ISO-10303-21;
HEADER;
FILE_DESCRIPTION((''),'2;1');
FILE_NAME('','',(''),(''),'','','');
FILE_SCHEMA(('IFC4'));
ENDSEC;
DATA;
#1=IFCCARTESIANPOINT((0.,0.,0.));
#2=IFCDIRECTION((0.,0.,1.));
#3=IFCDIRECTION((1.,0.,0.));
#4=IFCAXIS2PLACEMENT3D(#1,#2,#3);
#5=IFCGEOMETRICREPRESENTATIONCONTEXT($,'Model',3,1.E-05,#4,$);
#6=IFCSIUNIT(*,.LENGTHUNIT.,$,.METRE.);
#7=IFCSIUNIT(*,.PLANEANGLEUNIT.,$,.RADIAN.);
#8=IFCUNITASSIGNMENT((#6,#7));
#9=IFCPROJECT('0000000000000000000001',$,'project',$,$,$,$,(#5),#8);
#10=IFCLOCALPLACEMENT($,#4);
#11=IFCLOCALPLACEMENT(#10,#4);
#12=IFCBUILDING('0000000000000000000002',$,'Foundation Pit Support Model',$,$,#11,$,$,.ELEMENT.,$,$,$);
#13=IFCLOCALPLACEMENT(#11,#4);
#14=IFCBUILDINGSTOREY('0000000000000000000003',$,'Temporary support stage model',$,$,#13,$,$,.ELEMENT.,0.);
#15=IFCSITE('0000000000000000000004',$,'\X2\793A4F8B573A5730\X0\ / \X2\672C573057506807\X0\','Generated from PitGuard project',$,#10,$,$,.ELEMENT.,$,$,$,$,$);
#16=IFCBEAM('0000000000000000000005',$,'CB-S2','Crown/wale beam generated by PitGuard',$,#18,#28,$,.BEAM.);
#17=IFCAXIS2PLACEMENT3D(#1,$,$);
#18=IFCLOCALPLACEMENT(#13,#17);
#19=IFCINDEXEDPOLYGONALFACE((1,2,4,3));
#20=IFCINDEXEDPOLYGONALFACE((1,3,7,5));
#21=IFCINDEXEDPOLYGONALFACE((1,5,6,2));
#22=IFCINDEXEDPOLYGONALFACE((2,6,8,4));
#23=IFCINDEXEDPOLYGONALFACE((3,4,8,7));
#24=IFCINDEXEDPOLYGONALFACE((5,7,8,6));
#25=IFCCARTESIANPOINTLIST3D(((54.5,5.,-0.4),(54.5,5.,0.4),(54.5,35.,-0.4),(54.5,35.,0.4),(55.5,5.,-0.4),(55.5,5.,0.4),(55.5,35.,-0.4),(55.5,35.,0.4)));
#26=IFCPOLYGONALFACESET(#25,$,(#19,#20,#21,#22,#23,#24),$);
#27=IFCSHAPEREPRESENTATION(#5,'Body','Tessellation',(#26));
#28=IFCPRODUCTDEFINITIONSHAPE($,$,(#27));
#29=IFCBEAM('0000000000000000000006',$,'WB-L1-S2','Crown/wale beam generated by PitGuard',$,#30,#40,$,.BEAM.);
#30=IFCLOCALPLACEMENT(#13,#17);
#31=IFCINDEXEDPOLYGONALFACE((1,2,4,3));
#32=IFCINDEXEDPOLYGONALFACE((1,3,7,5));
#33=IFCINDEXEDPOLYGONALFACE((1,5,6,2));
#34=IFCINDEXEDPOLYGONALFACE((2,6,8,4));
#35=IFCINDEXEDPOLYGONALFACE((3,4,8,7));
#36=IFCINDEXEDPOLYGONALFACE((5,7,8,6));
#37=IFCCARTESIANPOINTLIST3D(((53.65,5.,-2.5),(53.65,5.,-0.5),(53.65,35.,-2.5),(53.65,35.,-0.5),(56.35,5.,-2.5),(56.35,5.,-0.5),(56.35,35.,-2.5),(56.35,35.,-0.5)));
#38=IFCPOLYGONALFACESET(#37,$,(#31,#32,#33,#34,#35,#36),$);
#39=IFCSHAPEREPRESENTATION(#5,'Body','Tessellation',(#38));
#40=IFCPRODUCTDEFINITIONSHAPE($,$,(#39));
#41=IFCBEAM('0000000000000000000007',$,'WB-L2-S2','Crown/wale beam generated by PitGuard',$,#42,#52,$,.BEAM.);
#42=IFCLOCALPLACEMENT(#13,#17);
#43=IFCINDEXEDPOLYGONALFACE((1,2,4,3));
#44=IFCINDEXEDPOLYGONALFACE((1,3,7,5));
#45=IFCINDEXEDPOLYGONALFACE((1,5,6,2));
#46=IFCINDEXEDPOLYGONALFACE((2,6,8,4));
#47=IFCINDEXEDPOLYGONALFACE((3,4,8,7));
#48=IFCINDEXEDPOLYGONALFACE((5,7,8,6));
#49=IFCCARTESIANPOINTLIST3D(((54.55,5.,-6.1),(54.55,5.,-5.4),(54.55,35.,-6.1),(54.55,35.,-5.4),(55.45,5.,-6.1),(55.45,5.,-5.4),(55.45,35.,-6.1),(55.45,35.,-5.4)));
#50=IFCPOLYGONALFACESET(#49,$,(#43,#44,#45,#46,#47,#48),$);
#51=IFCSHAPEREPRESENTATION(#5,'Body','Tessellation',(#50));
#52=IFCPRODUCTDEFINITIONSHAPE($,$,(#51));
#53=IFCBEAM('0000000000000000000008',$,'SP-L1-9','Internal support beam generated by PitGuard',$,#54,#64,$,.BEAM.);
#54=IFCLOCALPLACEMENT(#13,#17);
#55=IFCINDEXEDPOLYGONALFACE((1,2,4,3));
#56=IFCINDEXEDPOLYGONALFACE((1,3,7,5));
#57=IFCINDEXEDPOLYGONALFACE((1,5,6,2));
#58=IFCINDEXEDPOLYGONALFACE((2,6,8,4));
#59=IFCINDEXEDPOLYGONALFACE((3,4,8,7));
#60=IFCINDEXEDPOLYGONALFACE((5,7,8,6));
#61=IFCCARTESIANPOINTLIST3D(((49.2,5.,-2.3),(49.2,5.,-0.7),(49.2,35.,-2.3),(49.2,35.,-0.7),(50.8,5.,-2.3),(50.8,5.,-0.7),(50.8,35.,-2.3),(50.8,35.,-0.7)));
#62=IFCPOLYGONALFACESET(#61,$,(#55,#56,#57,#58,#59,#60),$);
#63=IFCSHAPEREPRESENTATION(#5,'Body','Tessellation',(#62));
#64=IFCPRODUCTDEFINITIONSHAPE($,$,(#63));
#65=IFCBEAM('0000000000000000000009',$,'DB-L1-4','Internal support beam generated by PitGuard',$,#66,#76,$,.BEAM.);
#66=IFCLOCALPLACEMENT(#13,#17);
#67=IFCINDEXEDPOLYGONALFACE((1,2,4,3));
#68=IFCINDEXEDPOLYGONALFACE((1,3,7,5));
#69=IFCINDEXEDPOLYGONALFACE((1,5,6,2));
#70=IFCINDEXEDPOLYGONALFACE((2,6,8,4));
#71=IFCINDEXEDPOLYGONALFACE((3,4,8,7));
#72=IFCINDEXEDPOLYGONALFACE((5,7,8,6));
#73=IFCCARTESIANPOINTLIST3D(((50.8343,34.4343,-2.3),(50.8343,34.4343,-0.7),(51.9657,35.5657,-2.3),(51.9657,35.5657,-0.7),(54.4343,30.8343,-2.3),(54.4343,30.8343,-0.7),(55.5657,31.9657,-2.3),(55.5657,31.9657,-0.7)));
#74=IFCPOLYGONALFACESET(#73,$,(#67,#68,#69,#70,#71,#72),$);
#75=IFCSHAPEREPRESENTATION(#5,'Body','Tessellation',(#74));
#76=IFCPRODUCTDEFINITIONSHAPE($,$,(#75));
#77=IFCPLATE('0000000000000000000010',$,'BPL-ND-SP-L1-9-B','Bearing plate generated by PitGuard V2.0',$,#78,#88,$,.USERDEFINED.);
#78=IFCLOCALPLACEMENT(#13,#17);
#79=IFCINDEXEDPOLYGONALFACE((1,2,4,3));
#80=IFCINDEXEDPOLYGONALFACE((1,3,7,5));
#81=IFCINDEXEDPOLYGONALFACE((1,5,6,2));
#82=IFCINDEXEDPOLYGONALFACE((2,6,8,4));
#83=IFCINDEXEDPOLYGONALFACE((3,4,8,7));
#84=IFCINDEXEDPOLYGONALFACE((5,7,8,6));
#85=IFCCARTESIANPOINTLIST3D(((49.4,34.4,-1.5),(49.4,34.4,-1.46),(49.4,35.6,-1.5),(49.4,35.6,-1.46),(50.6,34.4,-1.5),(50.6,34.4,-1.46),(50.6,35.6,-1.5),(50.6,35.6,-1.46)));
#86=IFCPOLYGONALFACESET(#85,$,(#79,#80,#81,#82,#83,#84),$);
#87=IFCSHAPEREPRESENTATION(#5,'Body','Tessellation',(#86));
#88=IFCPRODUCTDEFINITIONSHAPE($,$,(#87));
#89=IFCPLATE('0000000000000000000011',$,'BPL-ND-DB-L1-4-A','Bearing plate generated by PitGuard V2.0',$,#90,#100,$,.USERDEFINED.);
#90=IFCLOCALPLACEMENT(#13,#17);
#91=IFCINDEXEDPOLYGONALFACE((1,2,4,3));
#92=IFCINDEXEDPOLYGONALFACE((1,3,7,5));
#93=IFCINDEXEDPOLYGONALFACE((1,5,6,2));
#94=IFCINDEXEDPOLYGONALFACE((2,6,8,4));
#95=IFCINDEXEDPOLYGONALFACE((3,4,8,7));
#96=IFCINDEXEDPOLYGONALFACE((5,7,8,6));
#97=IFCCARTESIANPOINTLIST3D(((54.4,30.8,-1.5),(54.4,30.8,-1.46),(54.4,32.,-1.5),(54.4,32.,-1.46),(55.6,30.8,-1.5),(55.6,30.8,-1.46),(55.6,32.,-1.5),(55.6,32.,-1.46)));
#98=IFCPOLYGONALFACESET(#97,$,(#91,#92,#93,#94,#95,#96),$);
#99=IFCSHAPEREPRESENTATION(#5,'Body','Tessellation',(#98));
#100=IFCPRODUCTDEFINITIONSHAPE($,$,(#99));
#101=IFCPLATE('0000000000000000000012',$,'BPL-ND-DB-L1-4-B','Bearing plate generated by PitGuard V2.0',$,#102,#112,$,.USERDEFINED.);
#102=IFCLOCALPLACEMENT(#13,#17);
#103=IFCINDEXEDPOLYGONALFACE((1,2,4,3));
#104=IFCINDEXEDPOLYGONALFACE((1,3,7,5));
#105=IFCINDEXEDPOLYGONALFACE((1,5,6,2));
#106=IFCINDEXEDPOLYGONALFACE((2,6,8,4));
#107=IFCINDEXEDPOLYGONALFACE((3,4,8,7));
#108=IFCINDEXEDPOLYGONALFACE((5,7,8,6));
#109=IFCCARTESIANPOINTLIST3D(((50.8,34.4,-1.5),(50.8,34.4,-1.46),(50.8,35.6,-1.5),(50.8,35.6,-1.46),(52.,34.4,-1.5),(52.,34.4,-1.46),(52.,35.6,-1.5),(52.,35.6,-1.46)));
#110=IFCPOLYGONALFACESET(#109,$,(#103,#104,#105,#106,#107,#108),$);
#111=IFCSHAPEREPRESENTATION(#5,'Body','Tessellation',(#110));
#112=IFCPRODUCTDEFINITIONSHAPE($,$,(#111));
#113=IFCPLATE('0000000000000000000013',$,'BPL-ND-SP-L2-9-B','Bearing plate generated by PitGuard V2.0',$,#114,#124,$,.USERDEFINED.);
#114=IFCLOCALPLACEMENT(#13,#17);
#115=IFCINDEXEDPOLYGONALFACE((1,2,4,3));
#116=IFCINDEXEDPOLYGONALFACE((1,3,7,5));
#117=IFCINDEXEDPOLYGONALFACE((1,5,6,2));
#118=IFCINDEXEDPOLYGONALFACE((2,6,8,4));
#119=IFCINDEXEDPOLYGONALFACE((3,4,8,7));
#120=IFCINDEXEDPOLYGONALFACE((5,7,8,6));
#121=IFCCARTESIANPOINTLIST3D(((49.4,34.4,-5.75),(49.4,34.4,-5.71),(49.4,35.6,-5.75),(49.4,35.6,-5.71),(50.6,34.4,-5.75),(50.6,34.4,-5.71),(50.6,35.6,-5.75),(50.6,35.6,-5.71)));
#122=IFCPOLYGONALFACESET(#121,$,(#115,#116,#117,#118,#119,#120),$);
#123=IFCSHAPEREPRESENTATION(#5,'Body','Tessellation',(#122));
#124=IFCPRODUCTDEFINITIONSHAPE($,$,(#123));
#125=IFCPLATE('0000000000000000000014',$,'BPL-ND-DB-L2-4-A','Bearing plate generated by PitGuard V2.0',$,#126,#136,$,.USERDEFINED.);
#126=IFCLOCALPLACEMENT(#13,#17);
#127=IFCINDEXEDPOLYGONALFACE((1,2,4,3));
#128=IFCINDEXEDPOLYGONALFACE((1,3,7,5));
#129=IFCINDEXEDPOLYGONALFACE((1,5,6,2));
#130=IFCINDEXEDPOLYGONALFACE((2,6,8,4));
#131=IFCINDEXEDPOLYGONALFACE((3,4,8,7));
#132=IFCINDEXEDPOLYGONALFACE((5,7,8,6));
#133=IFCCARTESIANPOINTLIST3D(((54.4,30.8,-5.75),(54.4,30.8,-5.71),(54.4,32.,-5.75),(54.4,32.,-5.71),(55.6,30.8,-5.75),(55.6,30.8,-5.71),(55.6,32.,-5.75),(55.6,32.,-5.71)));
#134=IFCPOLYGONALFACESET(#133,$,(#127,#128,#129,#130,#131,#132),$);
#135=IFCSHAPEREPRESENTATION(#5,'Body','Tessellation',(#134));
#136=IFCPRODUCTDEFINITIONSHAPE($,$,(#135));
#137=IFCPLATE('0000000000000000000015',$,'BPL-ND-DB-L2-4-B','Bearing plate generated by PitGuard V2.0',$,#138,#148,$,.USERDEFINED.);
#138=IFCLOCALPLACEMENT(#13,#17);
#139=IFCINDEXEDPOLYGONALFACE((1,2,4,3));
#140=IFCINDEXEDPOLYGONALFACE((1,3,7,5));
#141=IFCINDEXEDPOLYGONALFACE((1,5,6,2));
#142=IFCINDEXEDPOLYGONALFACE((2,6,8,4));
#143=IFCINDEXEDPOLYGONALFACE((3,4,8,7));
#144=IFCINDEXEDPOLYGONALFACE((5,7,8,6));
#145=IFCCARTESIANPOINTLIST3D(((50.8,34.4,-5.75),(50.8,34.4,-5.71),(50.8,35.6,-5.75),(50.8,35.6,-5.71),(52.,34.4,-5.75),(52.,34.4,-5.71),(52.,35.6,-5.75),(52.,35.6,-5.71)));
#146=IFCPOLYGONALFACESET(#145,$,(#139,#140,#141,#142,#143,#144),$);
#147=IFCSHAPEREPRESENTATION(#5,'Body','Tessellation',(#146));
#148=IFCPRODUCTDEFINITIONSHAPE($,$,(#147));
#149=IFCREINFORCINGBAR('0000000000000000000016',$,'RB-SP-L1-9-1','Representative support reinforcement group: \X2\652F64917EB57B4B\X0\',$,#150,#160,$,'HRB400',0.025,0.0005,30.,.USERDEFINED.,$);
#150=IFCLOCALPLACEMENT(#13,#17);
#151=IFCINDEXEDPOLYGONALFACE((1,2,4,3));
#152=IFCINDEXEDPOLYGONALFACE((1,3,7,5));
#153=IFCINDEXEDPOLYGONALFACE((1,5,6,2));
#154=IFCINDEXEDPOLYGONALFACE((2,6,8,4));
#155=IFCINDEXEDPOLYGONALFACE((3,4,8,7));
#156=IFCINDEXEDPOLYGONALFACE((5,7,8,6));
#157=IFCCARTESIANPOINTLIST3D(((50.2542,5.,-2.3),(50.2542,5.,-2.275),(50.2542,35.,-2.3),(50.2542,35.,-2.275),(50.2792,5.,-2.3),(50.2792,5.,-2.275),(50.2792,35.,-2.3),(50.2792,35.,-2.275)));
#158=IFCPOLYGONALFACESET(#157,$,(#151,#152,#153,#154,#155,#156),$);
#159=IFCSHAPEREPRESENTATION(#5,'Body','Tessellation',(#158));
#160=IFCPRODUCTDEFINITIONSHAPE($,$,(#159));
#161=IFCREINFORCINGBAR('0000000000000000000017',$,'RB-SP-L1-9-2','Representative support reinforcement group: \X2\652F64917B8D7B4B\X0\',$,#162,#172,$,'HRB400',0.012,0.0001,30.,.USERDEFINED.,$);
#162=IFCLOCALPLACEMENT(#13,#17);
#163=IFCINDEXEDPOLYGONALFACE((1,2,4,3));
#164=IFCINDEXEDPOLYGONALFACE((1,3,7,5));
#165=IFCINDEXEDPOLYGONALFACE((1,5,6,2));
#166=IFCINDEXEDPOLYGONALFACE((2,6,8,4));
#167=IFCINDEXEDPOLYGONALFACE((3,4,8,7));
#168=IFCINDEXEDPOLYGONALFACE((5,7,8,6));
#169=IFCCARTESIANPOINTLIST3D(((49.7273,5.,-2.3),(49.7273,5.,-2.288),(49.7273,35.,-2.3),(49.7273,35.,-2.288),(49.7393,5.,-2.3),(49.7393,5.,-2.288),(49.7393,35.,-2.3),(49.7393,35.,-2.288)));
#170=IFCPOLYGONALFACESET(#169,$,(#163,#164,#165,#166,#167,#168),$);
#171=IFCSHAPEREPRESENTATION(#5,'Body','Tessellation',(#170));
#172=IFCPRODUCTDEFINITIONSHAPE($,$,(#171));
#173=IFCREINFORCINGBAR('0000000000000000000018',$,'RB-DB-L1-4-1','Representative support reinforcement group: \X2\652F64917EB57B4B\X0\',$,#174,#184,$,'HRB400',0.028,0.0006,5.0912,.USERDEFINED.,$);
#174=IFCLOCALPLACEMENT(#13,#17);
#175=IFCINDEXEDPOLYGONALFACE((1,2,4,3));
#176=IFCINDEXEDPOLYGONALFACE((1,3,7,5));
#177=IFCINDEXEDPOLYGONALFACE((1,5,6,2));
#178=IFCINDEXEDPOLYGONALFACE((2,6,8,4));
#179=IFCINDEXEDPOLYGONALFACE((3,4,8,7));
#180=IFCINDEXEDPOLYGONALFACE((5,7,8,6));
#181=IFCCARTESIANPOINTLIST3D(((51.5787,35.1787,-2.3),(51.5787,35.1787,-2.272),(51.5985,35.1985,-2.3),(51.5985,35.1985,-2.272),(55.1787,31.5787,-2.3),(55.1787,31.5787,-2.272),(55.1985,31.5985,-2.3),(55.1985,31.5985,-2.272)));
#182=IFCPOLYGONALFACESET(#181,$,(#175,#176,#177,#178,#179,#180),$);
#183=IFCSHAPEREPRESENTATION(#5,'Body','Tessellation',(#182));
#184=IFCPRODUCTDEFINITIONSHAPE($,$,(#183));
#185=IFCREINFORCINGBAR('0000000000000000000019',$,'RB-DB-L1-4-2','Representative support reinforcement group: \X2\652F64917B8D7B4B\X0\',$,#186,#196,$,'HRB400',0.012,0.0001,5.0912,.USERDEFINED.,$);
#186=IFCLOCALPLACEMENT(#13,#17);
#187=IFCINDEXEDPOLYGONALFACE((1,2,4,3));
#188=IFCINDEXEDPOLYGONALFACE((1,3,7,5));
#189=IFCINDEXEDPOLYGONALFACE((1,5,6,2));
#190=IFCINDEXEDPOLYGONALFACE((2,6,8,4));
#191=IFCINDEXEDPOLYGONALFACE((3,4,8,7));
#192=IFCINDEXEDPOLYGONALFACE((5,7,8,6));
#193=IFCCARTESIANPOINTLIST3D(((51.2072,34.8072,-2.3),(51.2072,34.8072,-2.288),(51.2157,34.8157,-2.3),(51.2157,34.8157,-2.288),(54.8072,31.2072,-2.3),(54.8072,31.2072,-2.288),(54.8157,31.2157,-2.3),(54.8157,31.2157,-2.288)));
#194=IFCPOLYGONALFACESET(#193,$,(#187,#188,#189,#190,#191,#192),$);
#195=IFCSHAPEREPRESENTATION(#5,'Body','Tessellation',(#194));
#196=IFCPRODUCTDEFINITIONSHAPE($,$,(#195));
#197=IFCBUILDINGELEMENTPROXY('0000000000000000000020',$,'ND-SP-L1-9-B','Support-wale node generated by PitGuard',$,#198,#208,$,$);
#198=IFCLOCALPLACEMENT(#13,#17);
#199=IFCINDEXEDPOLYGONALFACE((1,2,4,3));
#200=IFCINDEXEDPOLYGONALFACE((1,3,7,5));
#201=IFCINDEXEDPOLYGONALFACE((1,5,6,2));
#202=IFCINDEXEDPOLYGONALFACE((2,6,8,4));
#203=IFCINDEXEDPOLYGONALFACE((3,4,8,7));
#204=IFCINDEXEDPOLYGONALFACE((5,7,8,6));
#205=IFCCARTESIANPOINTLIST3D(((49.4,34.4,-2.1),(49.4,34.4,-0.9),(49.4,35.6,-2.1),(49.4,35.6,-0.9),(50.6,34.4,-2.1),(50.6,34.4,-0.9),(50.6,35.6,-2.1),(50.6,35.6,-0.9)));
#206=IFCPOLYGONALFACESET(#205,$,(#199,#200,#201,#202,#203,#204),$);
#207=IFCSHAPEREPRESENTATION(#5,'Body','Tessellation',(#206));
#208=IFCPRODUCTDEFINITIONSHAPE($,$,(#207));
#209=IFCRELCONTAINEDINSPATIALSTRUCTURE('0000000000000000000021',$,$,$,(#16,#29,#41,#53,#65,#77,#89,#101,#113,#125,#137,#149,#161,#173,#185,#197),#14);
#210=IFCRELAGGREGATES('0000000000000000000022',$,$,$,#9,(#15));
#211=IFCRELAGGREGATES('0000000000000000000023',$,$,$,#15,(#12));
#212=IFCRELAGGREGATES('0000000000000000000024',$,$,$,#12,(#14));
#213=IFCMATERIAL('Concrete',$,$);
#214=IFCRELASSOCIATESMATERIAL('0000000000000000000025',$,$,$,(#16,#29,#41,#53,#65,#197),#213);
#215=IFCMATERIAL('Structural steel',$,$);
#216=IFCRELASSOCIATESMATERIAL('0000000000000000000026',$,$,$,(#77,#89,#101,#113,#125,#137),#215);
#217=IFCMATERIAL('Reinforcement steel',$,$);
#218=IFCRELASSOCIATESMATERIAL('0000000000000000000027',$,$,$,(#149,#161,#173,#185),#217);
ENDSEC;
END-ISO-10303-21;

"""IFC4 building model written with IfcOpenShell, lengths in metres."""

from ifc_helpers import new_model, si_unit, frame, origin_with_axes, origin_2d, place, context, project, spatial, rectangle, extrude, material, element, save


model = new_model("IFC4")

# Units and contexts
model_context = context("Model", 3, precision=1e-05, world=origin_with_axes())
ifc_project = project(units=[si_unit("LENGTHUNIT", "METRE"), si_unit("PLANEANGLEUNIT", "RADIAN")], contexts=[model_context])

# Site, building, storey
site_placement = place(None, origin_with_axes())
site = spatial("IfcSite", under=ifc_project, at=site_placement, Name="示例场地 / 本地坐标", Description="Generated from PitGuard project", CompositionType="ELEMENT")
building_placement = place(site_placement, origin_with_axes())
building = spatial("IfcBuilding", under=site, at=building_placement, Name="Foundation Pit Support Model", CompositionType="ELEMENT")
storey_placement = place(building_placement, origin_with_axes())
storey = spatial("IfcBuildingStorey", under=building, at=storey_placement, Name="Temporary support stage model", CompositionType="ELEMENT", Elevation=0.0)

# Beams
ifc_material_1 = material(Name="Concrete")
beam_1_placement = place(storey_placement, frame((55.0, 20.0, -0.4), z_axis=(0.0, 0.0, 1.0), x_axis=(0.0, 1.0, 0.0)))
element("IfcBeam", 1, at=beam_1_placement, inside=storey, material=ifc_material_1, Name="CB-S2", Description="Crown/wale beam generated by PitGuard", PredefinedType="BEAM", context=model_context, shape_type="SweptSolid", body=[
    extrude(rectangle(XDim=30.0, YDim=1.0, at=origin_2d()), origin_with_axes(), (0.0, 0.0, 1.0), 0.8),
])
beam_2_placement = place(storey_placement, frame((55.0, 20.0, -2.5), z_axis=(0.0, 0.0, 1.0), x_axis=(0.0, 1.0, 0.0)))
element("IfcBeam", 2, at=beam_2_placement, inside=storey, material=ifc_material_1, Name="WB-L1-S2", Description="Crown/wale beam generated by PitGuard", PredefinedType="BEAM", context=model_context, shape_type="SweptSolid", body=[
    extrude(rectangle(XDim=30.0, YDim=2.7, at=origin_2d()), origin_with_axes(), (0.0, 0.0, 1.0), 2.0),
])
beam_3_placement = place(storey_placement, frame((55.0, 20.0, -6.1), z_axis=(0.0, 0.0, 1.0), x_axis=(0.0, 1.0, 0.0)))
element("IfcBeam", 3, at=beam_3_placement, inside=storey, material=ifc_material_1, Name="WB-L2-S2", Description="Crown/wale beam generated by PitGuard", PredefinedType="BEAM", context=model_context, shape_type="SweptSolid", body=[
    extrude(rectangle(XDim=30.0, YDim=0.9, at=origin_2d()), origin_with_axes(), (0.0, 0.0, 1.0), 0.7),
])
beam_4_placement = place(storey_placement, frame((50.0, 20.0, -2.3), z_axis=(0.0, 0.0, 1.0), x_axis=(0.0, 1.0, 0.0)))
element("IfcBeam", 4, at=beam_4_placement, inside=storey, material=ifc_material_1, Name="SP-L1-9", Description="Internal support beam generated by PitGuard", PredefinedType="BEAM", context=model_context, shape_type="SweptSolid", body=[
    extrude(rectangle(XDim=30.0, YDim=1.6, at=origin_2d()), origin_with_axes(), (0.0, 0.0, 1.0), 1.6),
])
beam_5_placement = place(storey_placement, frame((53.2, 33.2, -2.3), z_axis=(0.0, 0.0, 1.0), x_axis=(-0.707107, 0.707107, 0.0)))
element("IfcBeam", 5, at=beam_5_placement, inside=storey, material=ifc_material_1, Name="DB-L1-4", Description="Internal support beam generated by PitGuard", PredefinedType="BEAM", context=model_context, shape_type="SweptSolid", body=[
    extrude(rectangle(XDim=5.0912, YDim=1.6, at=origin_2d()), origin_with_axes(), (0.0, 0.0, 1.0), 1.6),
])

# Plates
ifc_material_2 = material(Name="Structural steel")
for number, where, z_axis, x_axis, name in (
    (6, (50.0, 35.0, -1.5), (0.0, 0.0, 1.0), (1.0, 0.0, 0.0), "BPL-ND-SP-L1-9-B"),
    (7, (55.0, 31.4, -1.5), (0.0, 0.0, 1.0), (1.0, 0.0, 0.0), "BPL-ND-DB-L1-4-A"),
    (8, (51.4, 35.0, -1.5), (0.0, 0.0, 1.0), (1.0, 0.0, 0.0), "BPL-ND-DB-L1-4-B"),
    (9, (50.0, 35.0, -5.75), (0.0, 0.0, 1.0), (1.0, 0.0, 0.0), "BPL-ND-SP-L2-9-B"),
    (10, (55.0, 31.4, -5.75), (0.0, 0.0, 1.0), (1.0, 0.0, 0.0), "BPL-ND-DB-L2-4-A"),
    (11, (51.4, 35.0, -5.75), (0.0, 0.0, 1.0), (1.0, 0.0, 0.0), "BPL-ND-DB-L2-4-B"),
):
    element("IfcPlate", number, at=place(storey_placement, frame(where, z_axis=z_axis, x_axis=x_axis)), inside=storey, material=ifc_material_2, Name=name, Description="Bearing plate generated by PitGuard V2.0", PredefinedType="USERDEFINED", context=model_context, shape_type="SweptSolid", body=[
        extrude(rectangle(XDim=1.2, YDim=1.2, at=origin_2d()), origin_with_axes(), (0.0, 0.0, 1.0), 0.04),
    ])

# Reinforcing bars
ifc_material_3 = material(Name="Reinforcement steel")
reinforcing_bar_1_placement = place(storey_placement, frame((50.2667, 20.0, -2.3), z_axis=(0.0, 0.0, 1.0), x_axis=(0.0, 1.0, 0.0)))
element("IfcReinforcingBar", 12, at=reinforcing_bar_1_placement, inside=storey, material=ifc_material_3, Name="RB-SP-L1-9-1", Description="Representative support reinforcement group: 支撑纵筋", SteelGrade="HRB400", BarLength=30.0, CrossSectionArea=0.0005, NominalDiameter=0.025, PredefinedType="USERDEFINED", context=model_context, shape_type="SweptSolid", body=[
    extrude(rectangle(XDim=30.0, YDim=0.025, at=origin_2d()), origin_with_axes(), (0.0, 0.0, 1.0), 0.025),
])
reinforcing_bar_2_placement = place(storey_placement, frame((49.7333, 20.0, -2.3), z_axis=(0.0, 0.0, 1.0), x_axis=(0.0, 1.0, 0.0)))
element("IfcReinforcingBar", 13, at=reinforcing_bar_2_placement, inside=storey, material=ifc_material_3, Name="RB-SP-L1-9-2", Description="Representative support reinforcement group: 支撑箍筋", SteelGrade="HRB400", BarLength=30.0, CrossSectionArea=0.0001, NominalDiameter=0.012, PredefinedType="USERDEFINED", context=model_context, shape_type="SweptSolid", body=[
    extrude(rectangle(XDim=30.0, YDim=0.012, at=origin_2d()), origin_with_axes(), (0.0, 0.0, 1.0), 0.012),
])
reinforcing_bar_3_placement = place(storey_placement, frame((53.3886, 33.3886, -2.3), z_axis=(0.0, 0.0, 1.0), x_axis=(-0.707107, 0.707107, 0.0)))
element("IfcReinforcingBar", 14, at=reinforcing_bar_3_placement, inside=storey, material=ifc_material_3, Name="RB-DB-L1-4-1", Description="Representative support reinforcement group: 支撑纵筋", SteelGrade="HRB400", BarLength=5.0912, CrossSectionArea=0.0006, NominalDiameter=0.028, PredefinedType="USERDEFINED", context=model_context, shape_type="SweptSolid", body=[
    extrude(rectangle(XDim=5.0912, YDim=0.028, at=origin_2d()), origin_with_axes(), (0.0, 0.0, 1.0), 0.028),
])
reinforcing_bar_4_placement = place(storey_placement, frame((53.0114, 33.0114, -2.3), z_axis=(0.0, 0.0, 1.0), x_axis=(-0.707107, 0.707107, 0.0)))
element("IfcReinforcingBar", 15, at=reinforcing_bar_4_placement, inside=storey, material=ifc_material_3, Name="RB-DB-L1-4-2", Description="Representative support reinforcement group: 支撑箍筋", SteelGrade="HRB400", BarLength=5.0912, CrossSectionArea=0.0001, NominalDiameter=0.012, PredefinedType="USERDEFINED", context=model_context, shape_type="SweptSolid", body=[
    extrude(rectangle(XDim=5.0912, YDim=0.012, at=origin_2d()), origin_with_axes(), (0.0, 0.0, 1.0), 0.012),
])

# Building element proxy
proxy_1_placement = place(storey_placement, frame((50.0, 35.0, -2.1), z_axis=(0.0, 0.0, 1.0), x_axis=(1.0, 0.0, 0.0)))
element("IfcBuildingElementProxy", 16, at=proxy_1_placement, inside=storey, material=ifc_material_1, Name="ND-SP-L1-9-B", Description="Support-wale node generated by PitGuard", context=model_context, shape_type="SweptSolid", body=[
    extrude(rectangle(XDim=1.2, YDim=1.2, at=origin_2d()), origin_with_axes(), (0.0, 0.0, 1.0), 1.2),
])

save(model, "model.ifc")
